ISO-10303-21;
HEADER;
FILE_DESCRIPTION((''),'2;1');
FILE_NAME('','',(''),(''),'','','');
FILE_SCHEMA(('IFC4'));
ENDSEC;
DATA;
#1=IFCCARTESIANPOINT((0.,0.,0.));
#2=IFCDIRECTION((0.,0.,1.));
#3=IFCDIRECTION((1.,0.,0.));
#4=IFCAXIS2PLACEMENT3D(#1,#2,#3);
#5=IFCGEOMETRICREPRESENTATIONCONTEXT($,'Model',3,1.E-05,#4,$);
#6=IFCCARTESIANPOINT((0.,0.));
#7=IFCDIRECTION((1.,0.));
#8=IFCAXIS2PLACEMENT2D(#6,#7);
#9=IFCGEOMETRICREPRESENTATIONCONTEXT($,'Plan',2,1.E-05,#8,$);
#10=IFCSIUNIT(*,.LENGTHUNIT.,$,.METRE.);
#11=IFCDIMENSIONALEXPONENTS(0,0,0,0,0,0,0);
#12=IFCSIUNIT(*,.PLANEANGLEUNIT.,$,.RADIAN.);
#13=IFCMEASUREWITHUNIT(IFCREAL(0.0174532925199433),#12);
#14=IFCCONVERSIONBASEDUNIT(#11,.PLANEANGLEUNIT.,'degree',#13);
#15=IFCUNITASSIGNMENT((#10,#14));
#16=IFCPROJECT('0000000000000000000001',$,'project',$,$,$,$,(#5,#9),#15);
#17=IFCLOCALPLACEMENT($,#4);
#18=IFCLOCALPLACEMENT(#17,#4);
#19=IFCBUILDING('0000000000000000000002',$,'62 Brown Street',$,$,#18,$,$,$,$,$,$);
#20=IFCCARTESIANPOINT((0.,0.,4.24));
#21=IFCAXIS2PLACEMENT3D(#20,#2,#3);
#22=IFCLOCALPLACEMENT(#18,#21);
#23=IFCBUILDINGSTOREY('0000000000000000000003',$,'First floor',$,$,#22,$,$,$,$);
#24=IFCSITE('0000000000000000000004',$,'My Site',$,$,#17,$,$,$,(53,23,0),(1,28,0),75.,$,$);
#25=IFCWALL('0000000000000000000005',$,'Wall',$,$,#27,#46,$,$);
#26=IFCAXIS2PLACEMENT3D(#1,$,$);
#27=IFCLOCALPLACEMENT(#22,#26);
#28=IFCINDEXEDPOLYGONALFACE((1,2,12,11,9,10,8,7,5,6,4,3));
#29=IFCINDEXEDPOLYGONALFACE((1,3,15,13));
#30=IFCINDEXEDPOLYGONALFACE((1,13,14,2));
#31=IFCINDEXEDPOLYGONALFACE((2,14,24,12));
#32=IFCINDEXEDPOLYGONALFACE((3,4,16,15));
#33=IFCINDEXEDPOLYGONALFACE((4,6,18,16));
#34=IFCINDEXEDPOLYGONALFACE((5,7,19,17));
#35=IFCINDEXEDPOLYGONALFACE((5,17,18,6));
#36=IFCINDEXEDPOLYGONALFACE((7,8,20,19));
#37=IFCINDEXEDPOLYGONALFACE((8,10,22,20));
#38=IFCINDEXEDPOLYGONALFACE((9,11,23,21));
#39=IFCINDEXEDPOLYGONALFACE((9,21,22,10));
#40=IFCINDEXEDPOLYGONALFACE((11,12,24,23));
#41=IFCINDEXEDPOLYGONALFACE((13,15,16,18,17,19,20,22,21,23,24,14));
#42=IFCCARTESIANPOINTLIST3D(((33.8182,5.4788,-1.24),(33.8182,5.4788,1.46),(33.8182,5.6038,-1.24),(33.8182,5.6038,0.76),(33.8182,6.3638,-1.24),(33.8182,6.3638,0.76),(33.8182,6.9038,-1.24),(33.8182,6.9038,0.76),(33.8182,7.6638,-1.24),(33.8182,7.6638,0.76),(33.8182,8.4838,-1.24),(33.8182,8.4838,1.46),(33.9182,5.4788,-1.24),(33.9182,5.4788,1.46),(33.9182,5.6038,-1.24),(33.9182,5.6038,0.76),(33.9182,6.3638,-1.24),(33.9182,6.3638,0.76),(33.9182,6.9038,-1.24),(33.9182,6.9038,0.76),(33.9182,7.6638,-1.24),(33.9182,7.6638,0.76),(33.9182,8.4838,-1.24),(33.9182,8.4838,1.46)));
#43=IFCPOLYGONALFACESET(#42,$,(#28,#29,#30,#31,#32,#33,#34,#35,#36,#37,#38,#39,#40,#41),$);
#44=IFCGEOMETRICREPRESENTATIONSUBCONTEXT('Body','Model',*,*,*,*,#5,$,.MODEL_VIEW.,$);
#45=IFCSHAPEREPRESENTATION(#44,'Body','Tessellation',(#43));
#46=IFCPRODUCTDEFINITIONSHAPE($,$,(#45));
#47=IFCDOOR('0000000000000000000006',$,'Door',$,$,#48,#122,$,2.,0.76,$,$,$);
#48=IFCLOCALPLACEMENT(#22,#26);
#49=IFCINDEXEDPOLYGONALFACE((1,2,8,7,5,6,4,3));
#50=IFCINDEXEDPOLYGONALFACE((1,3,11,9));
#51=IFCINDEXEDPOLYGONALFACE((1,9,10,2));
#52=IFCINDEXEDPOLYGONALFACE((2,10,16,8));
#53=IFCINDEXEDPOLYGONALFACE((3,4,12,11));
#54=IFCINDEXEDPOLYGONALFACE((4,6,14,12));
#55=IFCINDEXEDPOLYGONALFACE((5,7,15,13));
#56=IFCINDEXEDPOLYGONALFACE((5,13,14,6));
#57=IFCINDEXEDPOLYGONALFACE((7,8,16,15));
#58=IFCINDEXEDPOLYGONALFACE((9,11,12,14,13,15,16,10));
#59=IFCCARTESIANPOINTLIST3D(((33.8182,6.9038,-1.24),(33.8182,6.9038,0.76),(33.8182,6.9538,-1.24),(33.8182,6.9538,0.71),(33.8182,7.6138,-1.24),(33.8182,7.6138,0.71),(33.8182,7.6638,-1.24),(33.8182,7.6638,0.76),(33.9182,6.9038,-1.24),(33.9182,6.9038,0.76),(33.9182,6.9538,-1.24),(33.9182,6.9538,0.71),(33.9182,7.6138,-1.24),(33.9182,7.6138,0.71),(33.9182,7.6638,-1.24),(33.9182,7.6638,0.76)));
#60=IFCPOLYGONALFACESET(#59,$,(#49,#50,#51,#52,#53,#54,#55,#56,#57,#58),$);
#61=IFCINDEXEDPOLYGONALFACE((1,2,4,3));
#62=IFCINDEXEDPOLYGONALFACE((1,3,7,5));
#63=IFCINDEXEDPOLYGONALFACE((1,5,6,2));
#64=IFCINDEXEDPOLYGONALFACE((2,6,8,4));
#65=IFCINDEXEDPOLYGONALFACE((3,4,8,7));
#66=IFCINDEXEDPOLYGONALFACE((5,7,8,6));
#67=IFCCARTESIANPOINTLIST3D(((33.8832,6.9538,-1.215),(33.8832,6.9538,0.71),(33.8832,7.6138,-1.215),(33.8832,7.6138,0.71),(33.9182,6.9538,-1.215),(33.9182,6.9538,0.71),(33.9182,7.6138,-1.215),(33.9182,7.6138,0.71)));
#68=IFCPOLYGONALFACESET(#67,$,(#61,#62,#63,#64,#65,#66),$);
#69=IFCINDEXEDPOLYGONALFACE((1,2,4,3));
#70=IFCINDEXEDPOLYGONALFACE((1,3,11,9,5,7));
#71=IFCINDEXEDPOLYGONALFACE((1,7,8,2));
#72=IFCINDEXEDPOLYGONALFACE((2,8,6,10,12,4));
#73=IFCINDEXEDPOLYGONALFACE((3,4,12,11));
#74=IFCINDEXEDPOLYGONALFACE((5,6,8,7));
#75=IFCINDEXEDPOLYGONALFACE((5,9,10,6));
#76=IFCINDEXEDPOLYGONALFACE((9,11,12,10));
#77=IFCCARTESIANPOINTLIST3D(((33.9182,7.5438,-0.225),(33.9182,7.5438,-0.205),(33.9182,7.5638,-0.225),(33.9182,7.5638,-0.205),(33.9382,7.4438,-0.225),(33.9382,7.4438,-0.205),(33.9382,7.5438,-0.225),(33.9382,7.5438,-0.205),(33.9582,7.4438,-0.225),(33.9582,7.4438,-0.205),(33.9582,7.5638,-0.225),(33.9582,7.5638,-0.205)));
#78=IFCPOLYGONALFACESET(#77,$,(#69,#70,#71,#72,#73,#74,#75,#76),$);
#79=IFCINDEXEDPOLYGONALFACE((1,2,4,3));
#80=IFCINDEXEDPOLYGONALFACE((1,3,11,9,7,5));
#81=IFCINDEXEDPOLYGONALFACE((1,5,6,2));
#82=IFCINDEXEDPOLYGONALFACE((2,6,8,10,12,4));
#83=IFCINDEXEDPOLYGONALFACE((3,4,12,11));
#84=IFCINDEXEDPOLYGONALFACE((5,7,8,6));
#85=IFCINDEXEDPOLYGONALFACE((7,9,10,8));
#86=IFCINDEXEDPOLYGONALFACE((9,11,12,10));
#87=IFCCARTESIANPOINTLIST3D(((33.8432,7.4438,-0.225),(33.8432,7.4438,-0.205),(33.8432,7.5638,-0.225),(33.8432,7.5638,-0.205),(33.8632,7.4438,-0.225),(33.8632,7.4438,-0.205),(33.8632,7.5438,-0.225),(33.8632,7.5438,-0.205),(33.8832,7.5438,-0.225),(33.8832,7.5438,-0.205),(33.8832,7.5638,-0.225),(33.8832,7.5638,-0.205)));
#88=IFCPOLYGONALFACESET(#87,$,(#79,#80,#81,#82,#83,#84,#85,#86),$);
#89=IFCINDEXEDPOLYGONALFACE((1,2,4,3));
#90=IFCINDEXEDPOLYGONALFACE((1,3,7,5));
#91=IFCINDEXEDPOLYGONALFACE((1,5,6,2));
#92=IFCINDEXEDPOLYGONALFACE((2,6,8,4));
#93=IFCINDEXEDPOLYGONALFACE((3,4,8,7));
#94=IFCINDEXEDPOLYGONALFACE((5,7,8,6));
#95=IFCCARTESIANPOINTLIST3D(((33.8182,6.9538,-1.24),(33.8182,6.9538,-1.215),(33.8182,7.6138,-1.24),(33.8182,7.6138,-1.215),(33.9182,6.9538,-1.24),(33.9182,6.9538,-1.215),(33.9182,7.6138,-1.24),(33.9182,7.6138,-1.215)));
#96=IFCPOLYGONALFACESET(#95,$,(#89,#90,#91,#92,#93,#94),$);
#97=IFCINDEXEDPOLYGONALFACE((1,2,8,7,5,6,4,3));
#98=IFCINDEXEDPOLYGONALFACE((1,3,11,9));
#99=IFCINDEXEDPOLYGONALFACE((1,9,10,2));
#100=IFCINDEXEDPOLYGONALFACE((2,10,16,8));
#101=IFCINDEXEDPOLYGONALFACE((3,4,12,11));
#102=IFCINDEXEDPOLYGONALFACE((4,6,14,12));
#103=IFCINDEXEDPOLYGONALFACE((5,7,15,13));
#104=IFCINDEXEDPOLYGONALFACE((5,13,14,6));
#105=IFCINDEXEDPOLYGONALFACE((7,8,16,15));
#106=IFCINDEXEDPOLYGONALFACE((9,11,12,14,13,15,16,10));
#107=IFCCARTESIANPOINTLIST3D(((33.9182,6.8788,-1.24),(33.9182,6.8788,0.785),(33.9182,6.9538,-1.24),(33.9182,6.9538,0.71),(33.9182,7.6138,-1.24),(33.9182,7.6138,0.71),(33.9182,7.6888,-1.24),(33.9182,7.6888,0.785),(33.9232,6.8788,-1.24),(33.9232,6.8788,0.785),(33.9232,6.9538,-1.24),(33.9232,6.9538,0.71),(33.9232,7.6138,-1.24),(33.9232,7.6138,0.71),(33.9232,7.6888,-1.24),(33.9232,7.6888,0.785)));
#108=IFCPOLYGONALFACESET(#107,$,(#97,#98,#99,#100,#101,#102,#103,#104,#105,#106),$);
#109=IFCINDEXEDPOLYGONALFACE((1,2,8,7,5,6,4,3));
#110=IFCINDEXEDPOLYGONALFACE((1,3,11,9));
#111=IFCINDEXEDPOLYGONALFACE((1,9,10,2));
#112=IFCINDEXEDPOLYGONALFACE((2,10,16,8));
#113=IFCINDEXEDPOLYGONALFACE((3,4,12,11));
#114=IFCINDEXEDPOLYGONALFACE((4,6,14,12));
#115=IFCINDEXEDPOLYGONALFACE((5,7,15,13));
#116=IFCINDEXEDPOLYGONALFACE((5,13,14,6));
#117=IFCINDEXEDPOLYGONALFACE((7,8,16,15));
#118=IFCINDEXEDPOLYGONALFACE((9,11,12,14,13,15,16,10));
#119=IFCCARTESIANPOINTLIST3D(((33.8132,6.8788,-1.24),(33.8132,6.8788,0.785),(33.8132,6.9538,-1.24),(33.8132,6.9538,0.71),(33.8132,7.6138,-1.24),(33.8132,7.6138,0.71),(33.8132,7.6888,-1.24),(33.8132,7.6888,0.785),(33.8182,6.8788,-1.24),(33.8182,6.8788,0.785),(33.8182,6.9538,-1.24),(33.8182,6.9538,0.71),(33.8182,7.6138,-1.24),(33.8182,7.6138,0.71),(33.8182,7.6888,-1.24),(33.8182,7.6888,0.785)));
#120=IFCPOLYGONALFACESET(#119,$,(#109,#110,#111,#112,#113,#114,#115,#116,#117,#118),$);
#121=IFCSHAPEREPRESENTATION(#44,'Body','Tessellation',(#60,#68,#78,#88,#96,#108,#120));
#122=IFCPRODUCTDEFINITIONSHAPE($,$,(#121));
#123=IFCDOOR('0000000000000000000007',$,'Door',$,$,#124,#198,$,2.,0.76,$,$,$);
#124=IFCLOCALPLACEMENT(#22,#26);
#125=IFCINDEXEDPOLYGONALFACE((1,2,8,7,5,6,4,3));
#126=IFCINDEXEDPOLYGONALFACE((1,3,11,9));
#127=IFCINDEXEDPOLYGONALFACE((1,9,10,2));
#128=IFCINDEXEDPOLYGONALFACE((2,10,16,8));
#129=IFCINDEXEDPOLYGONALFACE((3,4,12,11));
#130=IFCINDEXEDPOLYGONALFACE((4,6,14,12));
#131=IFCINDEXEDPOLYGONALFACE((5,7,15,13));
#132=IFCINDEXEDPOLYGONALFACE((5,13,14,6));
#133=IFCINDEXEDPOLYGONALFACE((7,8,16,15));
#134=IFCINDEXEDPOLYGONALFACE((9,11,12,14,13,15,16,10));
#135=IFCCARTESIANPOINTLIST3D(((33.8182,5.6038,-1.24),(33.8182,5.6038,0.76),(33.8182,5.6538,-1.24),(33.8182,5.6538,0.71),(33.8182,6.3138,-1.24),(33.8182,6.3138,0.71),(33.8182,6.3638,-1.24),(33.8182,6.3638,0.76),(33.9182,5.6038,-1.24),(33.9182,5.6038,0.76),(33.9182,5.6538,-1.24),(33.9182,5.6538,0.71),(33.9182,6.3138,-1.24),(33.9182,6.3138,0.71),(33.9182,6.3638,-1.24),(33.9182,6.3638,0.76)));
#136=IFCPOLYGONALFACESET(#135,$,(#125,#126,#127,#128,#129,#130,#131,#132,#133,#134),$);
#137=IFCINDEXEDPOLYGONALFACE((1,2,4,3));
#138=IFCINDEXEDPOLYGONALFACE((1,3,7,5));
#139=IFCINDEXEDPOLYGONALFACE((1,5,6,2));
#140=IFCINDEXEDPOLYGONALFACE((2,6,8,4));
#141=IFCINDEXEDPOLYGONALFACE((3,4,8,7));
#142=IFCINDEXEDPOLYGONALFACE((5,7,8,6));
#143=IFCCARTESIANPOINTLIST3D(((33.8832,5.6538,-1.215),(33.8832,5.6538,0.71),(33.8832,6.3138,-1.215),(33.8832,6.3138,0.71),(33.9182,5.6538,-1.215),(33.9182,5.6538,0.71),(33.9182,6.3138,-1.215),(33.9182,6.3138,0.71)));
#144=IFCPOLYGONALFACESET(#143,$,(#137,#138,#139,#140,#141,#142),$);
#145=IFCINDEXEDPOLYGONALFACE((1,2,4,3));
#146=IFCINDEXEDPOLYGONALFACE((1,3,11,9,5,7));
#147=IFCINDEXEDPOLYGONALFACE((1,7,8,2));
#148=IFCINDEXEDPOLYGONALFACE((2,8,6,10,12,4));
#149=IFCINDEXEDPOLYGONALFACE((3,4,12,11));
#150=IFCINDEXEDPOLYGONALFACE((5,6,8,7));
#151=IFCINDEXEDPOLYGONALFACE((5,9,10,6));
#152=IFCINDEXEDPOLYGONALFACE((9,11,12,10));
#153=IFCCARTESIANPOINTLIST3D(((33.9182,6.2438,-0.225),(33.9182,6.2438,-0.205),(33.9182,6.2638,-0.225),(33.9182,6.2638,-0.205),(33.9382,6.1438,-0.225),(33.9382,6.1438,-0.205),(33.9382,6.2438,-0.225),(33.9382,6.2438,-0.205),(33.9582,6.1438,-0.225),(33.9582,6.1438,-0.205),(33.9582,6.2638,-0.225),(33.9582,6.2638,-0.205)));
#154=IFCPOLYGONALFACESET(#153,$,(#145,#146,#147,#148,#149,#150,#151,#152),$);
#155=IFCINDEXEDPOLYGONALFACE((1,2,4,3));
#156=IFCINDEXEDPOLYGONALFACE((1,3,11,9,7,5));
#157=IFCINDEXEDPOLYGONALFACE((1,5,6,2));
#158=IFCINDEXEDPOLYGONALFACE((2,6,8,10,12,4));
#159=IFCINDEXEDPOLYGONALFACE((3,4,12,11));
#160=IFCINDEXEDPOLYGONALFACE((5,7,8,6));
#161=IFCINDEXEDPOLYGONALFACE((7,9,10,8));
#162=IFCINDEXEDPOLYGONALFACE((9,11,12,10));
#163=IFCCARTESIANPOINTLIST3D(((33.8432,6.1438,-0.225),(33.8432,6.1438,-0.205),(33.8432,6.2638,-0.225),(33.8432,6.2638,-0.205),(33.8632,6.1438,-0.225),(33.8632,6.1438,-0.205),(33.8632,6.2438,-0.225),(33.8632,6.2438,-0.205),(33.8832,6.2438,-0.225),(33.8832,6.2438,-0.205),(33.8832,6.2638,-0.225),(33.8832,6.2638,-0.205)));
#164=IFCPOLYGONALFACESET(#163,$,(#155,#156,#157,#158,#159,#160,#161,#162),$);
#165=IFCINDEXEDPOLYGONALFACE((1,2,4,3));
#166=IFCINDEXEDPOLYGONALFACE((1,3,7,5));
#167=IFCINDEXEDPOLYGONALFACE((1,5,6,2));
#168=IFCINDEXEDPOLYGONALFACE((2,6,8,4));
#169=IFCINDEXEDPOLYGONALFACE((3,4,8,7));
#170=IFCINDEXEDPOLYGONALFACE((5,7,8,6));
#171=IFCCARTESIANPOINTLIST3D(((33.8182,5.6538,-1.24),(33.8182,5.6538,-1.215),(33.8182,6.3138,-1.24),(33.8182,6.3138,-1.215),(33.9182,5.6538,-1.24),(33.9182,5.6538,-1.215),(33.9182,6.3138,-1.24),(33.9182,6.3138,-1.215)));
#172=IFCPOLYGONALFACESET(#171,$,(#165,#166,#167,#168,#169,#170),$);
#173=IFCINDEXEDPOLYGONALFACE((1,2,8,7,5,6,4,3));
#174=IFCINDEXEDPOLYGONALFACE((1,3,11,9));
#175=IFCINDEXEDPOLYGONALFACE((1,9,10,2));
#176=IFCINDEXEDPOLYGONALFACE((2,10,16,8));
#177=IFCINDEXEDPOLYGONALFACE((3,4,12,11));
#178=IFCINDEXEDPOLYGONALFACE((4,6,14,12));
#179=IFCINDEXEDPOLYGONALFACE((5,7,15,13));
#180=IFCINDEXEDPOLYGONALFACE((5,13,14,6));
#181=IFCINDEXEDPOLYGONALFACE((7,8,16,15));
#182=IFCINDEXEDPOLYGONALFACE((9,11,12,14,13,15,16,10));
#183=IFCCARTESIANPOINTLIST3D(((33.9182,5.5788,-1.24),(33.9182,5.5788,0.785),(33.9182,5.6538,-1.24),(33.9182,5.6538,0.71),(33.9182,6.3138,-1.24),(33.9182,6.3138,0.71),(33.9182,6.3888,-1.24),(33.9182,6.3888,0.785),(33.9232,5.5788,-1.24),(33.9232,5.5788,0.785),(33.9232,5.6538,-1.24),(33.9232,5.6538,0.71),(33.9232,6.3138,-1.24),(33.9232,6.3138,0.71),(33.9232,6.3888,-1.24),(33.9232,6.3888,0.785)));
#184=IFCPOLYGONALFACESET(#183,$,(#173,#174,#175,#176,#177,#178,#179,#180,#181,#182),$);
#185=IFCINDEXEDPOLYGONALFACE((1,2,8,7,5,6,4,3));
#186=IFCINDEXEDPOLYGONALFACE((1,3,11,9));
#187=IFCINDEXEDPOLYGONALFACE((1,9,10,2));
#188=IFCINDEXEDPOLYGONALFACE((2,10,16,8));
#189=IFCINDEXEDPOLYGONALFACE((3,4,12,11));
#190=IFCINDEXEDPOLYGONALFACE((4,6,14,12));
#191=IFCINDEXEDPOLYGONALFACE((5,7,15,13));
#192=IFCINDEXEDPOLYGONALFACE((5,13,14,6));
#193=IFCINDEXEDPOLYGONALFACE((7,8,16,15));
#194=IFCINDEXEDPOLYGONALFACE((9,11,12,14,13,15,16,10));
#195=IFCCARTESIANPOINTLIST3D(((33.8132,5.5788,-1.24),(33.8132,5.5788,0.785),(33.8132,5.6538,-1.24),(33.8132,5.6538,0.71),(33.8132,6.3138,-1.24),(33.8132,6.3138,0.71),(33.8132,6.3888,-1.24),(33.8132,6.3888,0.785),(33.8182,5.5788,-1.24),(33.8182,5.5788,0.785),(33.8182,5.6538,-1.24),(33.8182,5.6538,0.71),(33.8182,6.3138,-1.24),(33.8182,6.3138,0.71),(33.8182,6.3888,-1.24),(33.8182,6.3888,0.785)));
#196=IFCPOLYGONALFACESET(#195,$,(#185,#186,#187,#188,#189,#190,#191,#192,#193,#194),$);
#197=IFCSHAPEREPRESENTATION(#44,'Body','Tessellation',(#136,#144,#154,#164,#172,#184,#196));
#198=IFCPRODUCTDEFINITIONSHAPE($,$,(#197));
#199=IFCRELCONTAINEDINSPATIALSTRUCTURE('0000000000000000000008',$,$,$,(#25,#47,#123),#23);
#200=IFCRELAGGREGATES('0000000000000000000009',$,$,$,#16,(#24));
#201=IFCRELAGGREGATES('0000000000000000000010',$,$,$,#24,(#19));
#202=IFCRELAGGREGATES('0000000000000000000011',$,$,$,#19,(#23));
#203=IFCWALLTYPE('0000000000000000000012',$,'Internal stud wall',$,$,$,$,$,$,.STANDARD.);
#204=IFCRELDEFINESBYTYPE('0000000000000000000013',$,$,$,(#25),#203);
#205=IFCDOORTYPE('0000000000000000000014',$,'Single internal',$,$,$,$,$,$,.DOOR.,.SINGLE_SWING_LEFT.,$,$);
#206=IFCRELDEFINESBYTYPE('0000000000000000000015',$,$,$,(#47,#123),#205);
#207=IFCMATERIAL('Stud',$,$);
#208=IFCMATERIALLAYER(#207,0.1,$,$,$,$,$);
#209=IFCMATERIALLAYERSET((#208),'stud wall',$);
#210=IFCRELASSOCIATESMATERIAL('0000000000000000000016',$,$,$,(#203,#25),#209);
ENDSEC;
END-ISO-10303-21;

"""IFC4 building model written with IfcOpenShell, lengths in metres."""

from ifc_helpers import new_model, entity, si_unit, converted_unit, frame, origin_with_axes, origin_2d_with_axis, place, context, subcontext, project, spatial, line, indexed_curve, outline, extrude, shape, source, transform, mapped, material, layer, layer_set, layer_usage, type_object, type_shapes, element, fill, save


model = new_model("IFC4")

# Units and contexts
model_context = context("Model", 3, precision=1e-05, world=origin_with_axes())
plan_context = context("Plan", 2, precision=1e-05, world=origin_2d_with_axis())
body_context_1 = subcontext(model_context, "Body", "Model", "MODEL_VIEW")
body_context_2 = subcontext(plan_context, "Body", "Plan", "PLAN_VIEW")
ifc_project = project(units=[si_unit("LENGTHUNIT", "METRE"), converted_unit("PLANEANGLEUNIT", "degree", entity("IfcReal", 0.0174532925199433), si_unit("PLANEANGLEUNIT", "RADIAN"), dimensions=[0, 0, 0, 0, 0, 0, 0])], contexts=[model_context, plan_context])

# Site, building, storey
site_placement = place(None, origin_with_axes())
site = spatial("IfcSite", under=ifc_project, at=site_placement, Name="My Site", RefLatitude=(53, 23, 0), RefLongitude=(1, 28, 0), RefElevation=75.0)
building_placement = place(site_placement, origin_with_axes())
building = spatial("IfcBuilding", under=site, at=building_placement, Name="62 Brown Street")
storey_placement = place(building_placement, frame((0.0, 0.0, 4.24), z_axis=(0.0, 0.0, 1.0), x_axis=(1.0, 0.0, 0.0)))
storey = spatial("IfcBuildingStorey", under=building, at=storey_placement, Name="First floor")

# Wall, openings, doors
ifc_material_1 = material(Name="Stud")
ifc_layer_1 = layer(ifc_material_1, 0.1)
ifc_layer_set_1 = layer_set([ifc_layer_1], Name="stud wall")
ifc_layer_usage_1 = layer_usage(ifc_layer_set_1, "AXIS2", "POSITIVE", 0.0)
wall_type_1 = type_object("IfcWallType", Name="Internal stud wall", PredefinedType="STANDARD", material=ifc_layer_set_1)
wall_1_placement = place(storey_placement, frame((33.9182, 5.4788, -1.24), z_axis=(0.0, 0.0, 1.0), x_axis=(0.000001, 1.0, 0.0)))
wall_1 = element("IfcWall", 1, at=wall_1_placement, inside=storey, type_object=wall_type_1, material=ifc_layer_usage_1, Name="Wall", context=body_context_1, shape_type="SweptSolid", body=[
    extrude(outline(indexed_curve([(0.0, 0.0), (0.0, 0.1), (3.005, 0.1), (3.005, 0.0), (0.0, 0.0)], self_intersect=False)), origin_with_axes(), (0.0, 0.0, 1.0), 2.7),
])
shared_shape_1 = source(origin_with_axes(), body_context_1, "Body", "SweptSolid", [
    extrude(outline(indexed_curve([(0.0, 0.0), (0.76, 0.0), (0.76, 2.0), (0.0, 2.0)], segments=[line(1, 2, 3, 4, 1)])), frame((0.0, -0.6, 0.0), z_axis=(0.0, -1.0, 0.0), x_axis=(1.0, 0.0, 0.0)), (0.0, 0.0, -1.0), 1.2),
])
opening_1_placement = place(wall_1_placement, frame((1.425, 0.0, 0.0), z_axis=(0.0, 0.0, 1.0), x_axis=(1.0, 0.0, 0.0)))
opening_1 = element("IfcOpeningElement", 2, at=opening_1_placement, cuts=wall_1, PredefinedType="OPENING", context=body_context_1, shape_type="MappedRepresentation", body=[
    mapped(shared_shape_1, transform((0.0, 0.0, 0.0), x_axis=(1.0, 0.0, 0.0), y_axis=(0.0, 1.0, 0.0), z_axis=(0.0, 0.0, 1.0), scale=1.0)),
])
opening_2_placement = place(wall_1_placement, frame((0.125, 0.0, 0.0), z_axis=(0.0, 0.0, 1.0), x_axis=(1.0, 0.0, 0.0)))
opening_2 = element("IfcOpeningElement", 3, at=opening_2_placement, cuts=wall_1, PredefinedType="OPENING", context=body_context_1, shape_type="MappedRepresentation", body=[
    mapped(shared_shape_1, transform((0.0, 0.0, 0.0), x_axis=(1.0, 0.0, 0.0), y_axis=(0.0, 1.0, 0.0), z_axis=(0.0, 0.0, 1.0), scale=1.0)),
])
door_type = type_object("IfcDoorType", Name="Single internal", OperationType="SINGLE_SWING_LEFT", PredefinedType="DOOR")
shared_shape_2 = source(origin_with_axes(), body_context_1, "Body", "SweptSolid", [
    extrude(outline(indexed_curve([(0.0, 0.0), (0.0, 2.0), (0.76, 2.0), (0.76, 0.0), (0.71, 0.0), (0.71, 1.95), (0.05, 1.95), (0.05, 0.0)], segments=[line(1, 2, 3, 4, 5, 6, 7, 8, 1)])), frame((0.0, 0.0, 0.0), z_axis=(0.0, -1.0, 0.0), x_axis=(1.0, 0.0, 0.0)), (0.0, 0.0, -1.0), 0.1),
    extrude(outline(indexed_curve([(0.0, 0.0), (0.66, 0.0), (0.66, 0.035), (0.0, 0.035)], segments=[line(1, 2, 3, 4, 1)])), frame((0.05, 0.0, 0.025), z_axis=(0.0, 0.0, 1.0), x_axis=(1.0, 0.0, 0.0)), (0.0, 0.0, 1.0), 1.925),
    extrude(outline(indexed_curve([(0.0, 0.0), (0.0, -0.04), (-0.12, -0.04), (-0.12, -0.02), (-0.02, -0.02), (-0.02, 0.0)], segments=[line(1, 2, 3, 4, 5, 6, 1)])), frame((0.66, 0.0, 1.015), z_axis=(0.0, 0.0, 1.0), x_axis=(1.0, 0.0, 0.0)), (0.0, 0.0, 1.0), 0.02),
    extrude(outline(indexed_curve([(0.0, 0.0), (0.0, 0.04), (-0.12, 0.04), (-0.12, 0.02), (-0.02, 0.02), (-0.02, 0.0)], segments=[line(1, 2, 3, 4, 5, 6, 1)])), frame((0.66, 0.035, 1.015), z_axis=(0.0, 0.0, 1.0), x_axis=(1.0, 0.0, 0.0)), (0.0, 0.0, 1.0), 0.02),
    extrude(outline(indexed_curve([(0.0, 0.0), (0.66, 0.0), (0.66, 0.1), (0.0, 0.1)], segments=[line(1, 2, 3, 4, 1)])), frame((0.05, 0.0, 0.0), z_axis=(0.0, 0.0, 1.0), x_axis=(1.0, 0.0, 0.0)), (0.0, 0.0, 1.0), 0.025),
    extrude(outline(indexed_curve([(0.0, 0.0), (0.0, 2.025), (0.81, 2.025), (0.81, 0.0), (0.735, 0.0), (0.735, 1.95), (0.075, 1.95), (0.075, 0.0)], segments=[line(1, 2, 3, 4, 5, 6, 7, 8, 1)])), frame((-0.025, -0.005, 0.0), z_axis=(0.0, -1.0, 0.0), x_axis=(1.0, 0.0, 0.0)), (0.0, 0.0, -1.0), 0.005),
    extrude(outline(indexed_curve([(0.0, 0.0), (0.0, 2.025), (0.81, 2.025), (0.81, 0.0), (0.735, 0.0), (0.735, 1.95), (0.075, 1.95), (0.075, 0.0)], segments=[line(1, 2, 3, 4, 5, 6, 7, 8, 1)])), frame((-0.025, 0.1, 0.0), z_axis=(0.0, -1.0, 0.0), x_axis=(1.0, 0.0, 0.0)), (0.0, 0.0, -1.0), 0.005),
])
shared_shape_3 = source(origin_with_axes(), body_context_2, "Body", "Curve2D", [
    entity("IfcIndexedPolyCurve", entity("IfcCartesianPointList2D", [[0.0, 0.0], [0.05, 0.0], [0.05, 0.1], [0.0, 0.1]]), [entity("IfcLineIndex", [1, 2, 3, 4, 1])]),
    entity("IfcIndexedPolyCurve", entity("IfcCartesianPointList2D", [[0.76, 0.0], [0.71, 0.0], [0.71, 0.1], [0.76, 0.1]]), [entity("IfcLineIndex", [1, 2, 3, 4, 1])]),
    entity("IfcTrimmedCurve", entity("IfcEllipse", entity("IfcAxis2Placement2D", entity("IfcCartesianPoint", [0.085, 0.1]), entity("IfcDirection", [1.0, 0.0])), 0.625, 0.66), [entity("IfcCartesianPoint", [0.71, 0.1])], [entity("IfcCartesianPoint", [0.085, 0.76])], True, "CARTESIAN"),
    entity("IfcIndexedPolyCurve", entity("IfcCartesianPointList2D", [[0.05, 0.1], [0.085, 0.1], [0.085, 0.76], [0.05, 0.76]]), [entity("IfcLineIndex", [1, 2, 3, 4, 1])]),
])
type_shapes(door_type, [shared_shape_2, shared_shape_3])
door_1_placement = place(opening_1_placement, frame((0.0, 0.0, 0.0), z_axis=(0.0, 0.0, 1.0), x_axis=(1.0, 0.0, 0.0)))
door_1 = element("IfcDoor", 4, at=door_1_placement, inside=storey, type_object=door_type, Name="Door", OverallHeight=2.0, OverallWidth=0.76, shapes=[
    shape(body_context_1, "Body", "MappedRepresentation", [mapped(shared_shape_2, transform((0.0, 0.0, 0.0), x_axis=(1.0, 0.0, 0.0), y_axis=(0.0, 1.0, 0.0), z_axis=(0.0, 0.0, 1.0), scale=1.0))]),
    shape(body_context_2, "Body", "MappedRepresentation", [mapped(shared_shape_3, transform((0.0, 0.0, 0.0), x_axis=(1.0, 0.0, 0.0), y_axis=(0.0, 1.0, 0.0), z_axis=(0.0, 0.0, 1.0), scale=1.0))]),
])
fill(opening_1, door_1)
door_2_placement = place(opening_2_placement, origin_with_axes())
door_2 = element("IfcDoor", 5, at=door_2_placement, inside=storey, type_object=door_type, Name="Door", OverallHeight=2.0, OverallWidth=0.76, shapes=[
    shape(body_context_1, "Body", "MappedRepresentation", [mapped(shared_shape_2, transform((0.0, 0.0, 0.0), x_axis=(1.0, 0.0, 0.0), y_axis=(0.0, 1.0, 0.0), z_axis=(0.0, 0.0, 1.0), scale=1.0))]),
    shape(body_context_2, "Body", "MappedRepresentation", [mapped(shared_shape_3, transform((0.0, 0.0, 0.0), x_axis=(1.0, 0.0, 0.0), y_axis=(0.0, 1.0, 0.0), z_axis=(0.0, 0.0, 1.0), scale=1.0))]),
])
fill(opening_2, door_2)

save(model, "model.ifc")
